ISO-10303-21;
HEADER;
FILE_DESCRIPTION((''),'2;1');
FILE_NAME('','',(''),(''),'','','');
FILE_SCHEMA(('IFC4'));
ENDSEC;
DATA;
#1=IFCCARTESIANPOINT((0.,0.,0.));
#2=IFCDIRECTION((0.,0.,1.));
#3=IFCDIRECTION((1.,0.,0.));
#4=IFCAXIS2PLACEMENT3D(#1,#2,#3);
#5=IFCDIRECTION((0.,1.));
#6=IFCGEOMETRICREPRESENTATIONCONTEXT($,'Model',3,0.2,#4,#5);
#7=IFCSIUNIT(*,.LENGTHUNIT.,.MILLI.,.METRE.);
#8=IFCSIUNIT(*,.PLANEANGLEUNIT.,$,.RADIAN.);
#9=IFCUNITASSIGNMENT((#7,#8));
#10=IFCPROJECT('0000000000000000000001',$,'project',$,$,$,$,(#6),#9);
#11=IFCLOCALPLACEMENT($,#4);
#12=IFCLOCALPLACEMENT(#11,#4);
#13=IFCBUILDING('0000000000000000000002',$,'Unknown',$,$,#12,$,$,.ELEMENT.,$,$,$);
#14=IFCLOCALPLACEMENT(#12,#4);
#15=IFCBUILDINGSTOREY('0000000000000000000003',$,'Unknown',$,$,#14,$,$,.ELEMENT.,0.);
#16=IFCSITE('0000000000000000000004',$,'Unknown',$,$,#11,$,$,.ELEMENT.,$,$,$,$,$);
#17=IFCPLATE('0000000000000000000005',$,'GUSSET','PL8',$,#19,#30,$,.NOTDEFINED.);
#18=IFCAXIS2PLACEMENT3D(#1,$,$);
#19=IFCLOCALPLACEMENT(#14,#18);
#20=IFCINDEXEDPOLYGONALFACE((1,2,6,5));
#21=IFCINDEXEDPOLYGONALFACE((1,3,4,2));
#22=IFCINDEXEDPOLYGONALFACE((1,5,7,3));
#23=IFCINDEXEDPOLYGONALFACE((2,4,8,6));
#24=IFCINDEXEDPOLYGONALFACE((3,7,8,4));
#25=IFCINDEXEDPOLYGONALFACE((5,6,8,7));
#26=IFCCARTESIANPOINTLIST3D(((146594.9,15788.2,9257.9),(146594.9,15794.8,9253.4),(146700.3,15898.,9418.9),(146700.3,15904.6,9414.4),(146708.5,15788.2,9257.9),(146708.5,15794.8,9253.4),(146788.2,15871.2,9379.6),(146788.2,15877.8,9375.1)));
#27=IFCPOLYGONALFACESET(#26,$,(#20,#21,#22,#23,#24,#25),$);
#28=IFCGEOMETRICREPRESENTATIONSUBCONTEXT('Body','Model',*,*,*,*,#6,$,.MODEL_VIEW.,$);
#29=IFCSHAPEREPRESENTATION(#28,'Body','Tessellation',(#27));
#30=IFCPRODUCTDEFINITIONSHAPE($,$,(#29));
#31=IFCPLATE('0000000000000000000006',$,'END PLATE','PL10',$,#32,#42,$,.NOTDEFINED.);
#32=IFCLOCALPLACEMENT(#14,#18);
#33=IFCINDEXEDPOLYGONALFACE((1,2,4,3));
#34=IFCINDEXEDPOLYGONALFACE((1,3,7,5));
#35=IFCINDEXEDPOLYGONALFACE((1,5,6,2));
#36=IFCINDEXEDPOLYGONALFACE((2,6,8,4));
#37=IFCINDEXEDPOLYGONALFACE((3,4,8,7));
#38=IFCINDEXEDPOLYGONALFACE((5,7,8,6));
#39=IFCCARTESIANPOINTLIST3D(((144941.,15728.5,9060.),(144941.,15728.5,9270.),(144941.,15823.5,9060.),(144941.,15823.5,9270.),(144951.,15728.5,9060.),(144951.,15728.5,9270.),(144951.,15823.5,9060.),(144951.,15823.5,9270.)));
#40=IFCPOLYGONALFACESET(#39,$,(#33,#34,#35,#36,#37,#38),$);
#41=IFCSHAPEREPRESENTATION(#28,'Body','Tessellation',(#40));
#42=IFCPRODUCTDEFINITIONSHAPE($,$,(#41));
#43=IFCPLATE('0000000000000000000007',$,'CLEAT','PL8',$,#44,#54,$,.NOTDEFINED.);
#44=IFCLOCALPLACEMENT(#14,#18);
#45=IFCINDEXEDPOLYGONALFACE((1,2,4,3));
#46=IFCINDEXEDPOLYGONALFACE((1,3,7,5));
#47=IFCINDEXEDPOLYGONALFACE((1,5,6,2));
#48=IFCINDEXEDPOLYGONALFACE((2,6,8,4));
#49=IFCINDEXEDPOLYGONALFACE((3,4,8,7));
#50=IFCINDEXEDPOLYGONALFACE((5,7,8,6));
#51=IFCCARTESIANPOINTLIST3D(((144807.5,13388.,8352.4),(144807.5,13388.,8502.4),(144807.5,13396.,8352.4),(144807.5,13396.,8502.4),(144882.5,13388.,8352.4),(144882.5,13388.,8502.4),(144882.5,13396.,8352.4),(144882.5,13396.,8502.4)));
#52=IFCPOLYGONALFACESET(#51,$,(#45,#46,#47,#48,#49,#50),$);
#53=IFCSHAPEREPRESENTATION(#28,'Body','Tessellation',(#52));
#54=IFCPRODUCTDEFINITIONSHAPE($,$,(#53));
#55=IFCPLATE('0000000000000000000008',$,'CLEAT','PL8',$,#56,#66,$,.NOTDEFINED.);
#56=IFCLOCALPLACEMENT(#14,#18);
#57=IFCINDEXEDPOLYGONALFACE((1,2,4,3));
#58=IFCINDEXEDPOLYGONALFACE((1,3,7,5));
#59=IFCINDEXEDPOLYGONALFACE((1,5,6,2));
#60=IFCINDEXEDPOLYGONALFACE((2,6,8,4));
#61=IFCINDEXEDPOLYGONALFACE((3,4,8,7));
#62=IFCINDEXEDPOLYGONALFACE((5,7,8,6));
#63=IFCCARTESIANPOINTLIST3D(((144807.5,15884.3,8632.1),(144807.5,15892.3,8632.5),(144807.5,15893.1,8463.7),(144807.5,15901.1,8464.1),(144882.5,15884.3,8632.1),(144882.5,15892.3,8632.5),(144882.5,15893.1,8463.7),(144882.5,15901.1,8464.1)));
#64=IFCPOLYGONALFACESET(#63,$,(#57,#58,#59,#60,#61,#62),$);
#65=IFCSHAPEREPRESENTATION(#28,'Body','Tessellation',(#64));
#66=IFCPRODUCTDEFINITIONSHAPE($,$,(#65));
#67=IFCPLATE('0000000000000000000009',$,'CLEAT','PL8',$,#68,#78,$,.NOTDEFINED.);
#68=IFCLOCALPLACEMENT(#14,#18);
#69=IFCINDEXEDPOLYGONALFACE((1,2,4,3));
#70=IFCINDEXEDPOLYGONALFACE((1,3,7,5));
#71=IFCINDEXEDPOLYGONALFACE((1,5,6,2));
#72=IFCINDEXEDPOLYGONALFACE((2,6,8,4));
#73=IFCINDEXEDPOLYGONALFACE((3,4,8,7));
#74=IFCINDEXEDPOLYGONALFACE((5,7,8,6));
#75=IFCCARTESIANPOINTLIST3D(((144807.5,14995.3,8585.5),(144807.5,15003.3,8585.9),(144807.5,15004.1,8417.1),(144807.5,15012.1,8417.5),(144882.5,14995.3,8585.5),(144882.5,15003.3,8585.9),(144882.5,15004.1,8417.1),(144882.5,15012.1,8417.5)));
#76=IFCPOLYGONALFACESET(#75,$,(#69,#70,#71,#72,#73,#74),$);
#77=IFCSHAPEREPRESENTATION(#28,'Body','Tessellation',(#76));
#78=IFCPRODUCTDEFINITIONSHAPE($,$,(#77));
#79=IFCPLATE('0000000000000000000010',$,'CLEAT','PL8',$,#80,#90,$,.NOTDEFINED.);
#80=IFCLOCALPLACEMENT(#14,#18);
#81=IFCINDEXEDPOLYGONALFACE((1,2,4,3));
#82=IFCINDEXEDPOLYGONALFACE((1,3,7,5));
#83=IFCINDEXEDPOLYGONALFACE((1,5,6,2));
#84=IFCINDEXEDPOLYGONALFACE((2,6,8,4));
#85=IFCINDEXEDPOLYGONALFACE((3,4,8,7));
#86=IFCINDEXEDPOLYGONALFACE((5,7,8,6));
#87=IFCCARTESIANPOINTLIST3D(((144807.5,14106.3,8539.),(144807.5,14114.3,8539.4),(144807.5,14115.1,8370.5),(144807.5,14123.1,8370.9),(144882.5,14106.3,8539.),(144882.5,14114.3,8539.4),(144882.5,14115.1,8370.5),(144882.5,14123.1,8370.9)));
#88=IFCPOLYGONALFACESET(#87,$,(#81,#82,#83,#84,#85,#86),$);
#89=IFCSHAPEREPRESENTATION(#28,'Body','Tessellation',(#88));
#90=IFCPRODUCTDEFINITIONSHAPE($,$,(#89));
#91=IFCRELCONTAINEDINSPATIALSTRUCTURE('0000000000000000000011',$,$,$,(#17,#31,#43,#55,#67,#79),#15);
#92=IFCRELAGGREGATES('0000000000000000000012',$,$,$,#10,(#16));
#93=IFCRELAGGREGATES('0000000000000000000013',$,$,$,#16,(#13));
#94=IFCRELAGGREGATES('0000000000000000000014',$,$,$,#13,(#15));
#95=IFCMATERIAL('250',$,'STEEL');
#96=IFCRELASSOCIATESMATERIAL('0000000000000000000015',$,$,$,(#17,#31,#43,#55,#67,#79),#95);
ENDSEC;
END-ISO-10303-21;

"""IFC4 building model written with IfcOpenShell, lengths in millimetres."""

from ifc_helpers import new_model, si_unit, direction, frame, origin_with_axes, place, context, subcontext, project, spatial, line, indexed_curve, outline, extrude, material, element, save


model = new_model("IFC4")

# Units and contexts
model_context = context("Model", 3, precision=0.2, world=origin_with_axes(), true_north=direction((0.0, 1.0)))
body_context = subcontext(model_context, "Body", "Model", "MODEL_VIEW")
ifc_project = project(units=[si_unit("LENGTHUNIT", "METRE", prefix="MILLI"), si_unit("PLANEANGLEUNIT", "RADIAN")], contexts=[model_context])

# Site, building, storey
site_placement = place(None, origin_with_axes())
site = spatial("IfcSite", under=ifc_project, at=site_placement, Name="Unknown", CompositionType="ELEMENT")
building_placement = place(site_placement, origin_with_axes())
building = spatial("IfcBuilding", under=site, at=building_placement, Name="Unknown", CompositionType="ELEMENT")
storey_placement = place(building_placement, origin_with_axes())
storey = spatial("IfcBuildingStorey", under=building, at=storey_placement, Name="Unknown", CompositionType="ELEMENT", Elevation=0.0)

# Plates
ifc_material_1 = material(Name="250", Category="STEEL")
plate_1_placement = place(storey_placement, frame((146708.5, 15791.5, 9255.7), z_axis=(0.0, -0.826156, 0.563442), x_axis=(0.475857, 0.49556, 0.726622)))
element("IfcPlate", 1, at=plate_1_placement, inside=storey, material=ifc_material_1, Name="GUSSET", Description="PL8", PredefinedType="NOTDEFINED", context=body_context, shape_type="SolidModel", body=[
    extrude(outline(indexed_curve([(0.0, 0.0), (167.5, 0.0), (167.5, 99.9), (-54.1, 99.9)], segments=[line(1, 2, 3, 4, 1)])), frame((0.0, 0.0, 4.0), z_axis=(0.0, 0.0, 1.0), x_axis=(1.0, 0.0, 0.0)), (0.0, 0.0, -1.0), 8.0),
])
plate_2_placement = place(storey_placement, frame((144946.0, 15823.5, 9060.0), z_axis=(-1.0, 0.0, 0.0), x_axis=(0.0, -1.0, 0.0)))
element("IfcPlate", 2, at=plate_2_placement, inside=storey, material=ifc_material_1, Name="END PLATE", Description="PL10", PredefinedType="NOTDEFINED", context=body_context, shape_type="SolidModel", body=[
    extrude(outline(indexed_curve([(0.0, 0.0), (95.0, 0.0), (95.0, 210.0), (0.0, 210.0)], segments=[line(1, 2, 3, 4, 1)])), frame((0.0, 0.0, 5.0), z_axis=(0.0, 0.0, 1.0), x_axis=(1.0, 0.0, 0.0)), (0.0, 0.0, -1.0), 10.0),
])
plate_3_placement = place(storey_placement, frame((144807.5, 13392.0, 8502.4), z_axis=(0.0, 1.0, 0.0), x_axis=(1.0, 0.0, 0.0)))
element("IfcPlate", 3, at=plate_3_placement, inside=storey, material=ifc_material_1, Name="CLEAT", Description="PL8", PredefinedType="NOTDEFINED", context=body_context, shape_type="SolidModel", body=[
    extrude(outline(indexed_curve([(0.0, 0.0), (75.0, 0.0), (75.0, 150.0), (0.0, 150.0)], segments=[line(1, 2, 3, 4, 1)])), frame((0.0, 0.0, 4.0), z_axis=(0.0, 0.0, 1.0), x_axis=(1.0, 0.0, 0.0)), (0.0, 0.0, -1.0), 8.0),
])
for number, where, z_axis, x_axis, name in (
    (4, (144807.5, 15888.3, 8632.3), (0.0, 0.998637, 0.052185), (1.0, 0.0, 0.0), "CLEAT"),
    (5, (144807.5, 14999.3, 8585.7), (0.0, 0.998637, 0.052185), (1.0, 0.0, 0.0), "CLEAT"),
):
    element("IfcPlate", number, at=place(storey_placement, frame(where, z_axis=z_axis, x_axis=x_axis)), inside=storey, material=ifc_material_1, Name=name, Description="PL8", PredefinedType="NOTDEFINED", context=body_context, shape_type="SolidModel", body=[
        extrude(outline(indexed_curve([(0.0, 0.0), (75.0, 0.0), (75.0, 168.6), (0.0, 168.6)], segments=[line(1, 2, 3, 4, 1)])), frame((0.0, 0.0, 4.0), z_axis=(0.0, 0.0, 1.0), x_axis=(1.0, 0.0, 0.0)), (0.0, 0.0, -1.0), 8.0),
    ])
plate_4_placement = place(storey_placement, frame((144807.5, 14110.3, 8539.2), z_axis=(0.0, 0.998639, 0.052154), x_axis=(1.0, 0.0, 0.0)))
element("IfcPlate", 6, at=plate_4_placement, inside=storey, material=ifc_material_1, Name="CLEAT", Description="PL8", PredefinedType="NOTDEFINED", context=body_context, shape_type="SolidModel", body=[
    extrude(outline(indexed_curve([(0.0, 0.0), (75.0, 0.0), (75.0, 168.7), (0.0, 168.7)], segments=[line(1, 2, 3, 4, 1)])), frame((0.0, 0.0, 4.0), z_axis=(0.0, 0.0, 1.0), x_axis=(1.0, 0.0, 0.0)), (0.0, 0.0, -1.0), 8.0),
])

save(model, "model.ifc")
